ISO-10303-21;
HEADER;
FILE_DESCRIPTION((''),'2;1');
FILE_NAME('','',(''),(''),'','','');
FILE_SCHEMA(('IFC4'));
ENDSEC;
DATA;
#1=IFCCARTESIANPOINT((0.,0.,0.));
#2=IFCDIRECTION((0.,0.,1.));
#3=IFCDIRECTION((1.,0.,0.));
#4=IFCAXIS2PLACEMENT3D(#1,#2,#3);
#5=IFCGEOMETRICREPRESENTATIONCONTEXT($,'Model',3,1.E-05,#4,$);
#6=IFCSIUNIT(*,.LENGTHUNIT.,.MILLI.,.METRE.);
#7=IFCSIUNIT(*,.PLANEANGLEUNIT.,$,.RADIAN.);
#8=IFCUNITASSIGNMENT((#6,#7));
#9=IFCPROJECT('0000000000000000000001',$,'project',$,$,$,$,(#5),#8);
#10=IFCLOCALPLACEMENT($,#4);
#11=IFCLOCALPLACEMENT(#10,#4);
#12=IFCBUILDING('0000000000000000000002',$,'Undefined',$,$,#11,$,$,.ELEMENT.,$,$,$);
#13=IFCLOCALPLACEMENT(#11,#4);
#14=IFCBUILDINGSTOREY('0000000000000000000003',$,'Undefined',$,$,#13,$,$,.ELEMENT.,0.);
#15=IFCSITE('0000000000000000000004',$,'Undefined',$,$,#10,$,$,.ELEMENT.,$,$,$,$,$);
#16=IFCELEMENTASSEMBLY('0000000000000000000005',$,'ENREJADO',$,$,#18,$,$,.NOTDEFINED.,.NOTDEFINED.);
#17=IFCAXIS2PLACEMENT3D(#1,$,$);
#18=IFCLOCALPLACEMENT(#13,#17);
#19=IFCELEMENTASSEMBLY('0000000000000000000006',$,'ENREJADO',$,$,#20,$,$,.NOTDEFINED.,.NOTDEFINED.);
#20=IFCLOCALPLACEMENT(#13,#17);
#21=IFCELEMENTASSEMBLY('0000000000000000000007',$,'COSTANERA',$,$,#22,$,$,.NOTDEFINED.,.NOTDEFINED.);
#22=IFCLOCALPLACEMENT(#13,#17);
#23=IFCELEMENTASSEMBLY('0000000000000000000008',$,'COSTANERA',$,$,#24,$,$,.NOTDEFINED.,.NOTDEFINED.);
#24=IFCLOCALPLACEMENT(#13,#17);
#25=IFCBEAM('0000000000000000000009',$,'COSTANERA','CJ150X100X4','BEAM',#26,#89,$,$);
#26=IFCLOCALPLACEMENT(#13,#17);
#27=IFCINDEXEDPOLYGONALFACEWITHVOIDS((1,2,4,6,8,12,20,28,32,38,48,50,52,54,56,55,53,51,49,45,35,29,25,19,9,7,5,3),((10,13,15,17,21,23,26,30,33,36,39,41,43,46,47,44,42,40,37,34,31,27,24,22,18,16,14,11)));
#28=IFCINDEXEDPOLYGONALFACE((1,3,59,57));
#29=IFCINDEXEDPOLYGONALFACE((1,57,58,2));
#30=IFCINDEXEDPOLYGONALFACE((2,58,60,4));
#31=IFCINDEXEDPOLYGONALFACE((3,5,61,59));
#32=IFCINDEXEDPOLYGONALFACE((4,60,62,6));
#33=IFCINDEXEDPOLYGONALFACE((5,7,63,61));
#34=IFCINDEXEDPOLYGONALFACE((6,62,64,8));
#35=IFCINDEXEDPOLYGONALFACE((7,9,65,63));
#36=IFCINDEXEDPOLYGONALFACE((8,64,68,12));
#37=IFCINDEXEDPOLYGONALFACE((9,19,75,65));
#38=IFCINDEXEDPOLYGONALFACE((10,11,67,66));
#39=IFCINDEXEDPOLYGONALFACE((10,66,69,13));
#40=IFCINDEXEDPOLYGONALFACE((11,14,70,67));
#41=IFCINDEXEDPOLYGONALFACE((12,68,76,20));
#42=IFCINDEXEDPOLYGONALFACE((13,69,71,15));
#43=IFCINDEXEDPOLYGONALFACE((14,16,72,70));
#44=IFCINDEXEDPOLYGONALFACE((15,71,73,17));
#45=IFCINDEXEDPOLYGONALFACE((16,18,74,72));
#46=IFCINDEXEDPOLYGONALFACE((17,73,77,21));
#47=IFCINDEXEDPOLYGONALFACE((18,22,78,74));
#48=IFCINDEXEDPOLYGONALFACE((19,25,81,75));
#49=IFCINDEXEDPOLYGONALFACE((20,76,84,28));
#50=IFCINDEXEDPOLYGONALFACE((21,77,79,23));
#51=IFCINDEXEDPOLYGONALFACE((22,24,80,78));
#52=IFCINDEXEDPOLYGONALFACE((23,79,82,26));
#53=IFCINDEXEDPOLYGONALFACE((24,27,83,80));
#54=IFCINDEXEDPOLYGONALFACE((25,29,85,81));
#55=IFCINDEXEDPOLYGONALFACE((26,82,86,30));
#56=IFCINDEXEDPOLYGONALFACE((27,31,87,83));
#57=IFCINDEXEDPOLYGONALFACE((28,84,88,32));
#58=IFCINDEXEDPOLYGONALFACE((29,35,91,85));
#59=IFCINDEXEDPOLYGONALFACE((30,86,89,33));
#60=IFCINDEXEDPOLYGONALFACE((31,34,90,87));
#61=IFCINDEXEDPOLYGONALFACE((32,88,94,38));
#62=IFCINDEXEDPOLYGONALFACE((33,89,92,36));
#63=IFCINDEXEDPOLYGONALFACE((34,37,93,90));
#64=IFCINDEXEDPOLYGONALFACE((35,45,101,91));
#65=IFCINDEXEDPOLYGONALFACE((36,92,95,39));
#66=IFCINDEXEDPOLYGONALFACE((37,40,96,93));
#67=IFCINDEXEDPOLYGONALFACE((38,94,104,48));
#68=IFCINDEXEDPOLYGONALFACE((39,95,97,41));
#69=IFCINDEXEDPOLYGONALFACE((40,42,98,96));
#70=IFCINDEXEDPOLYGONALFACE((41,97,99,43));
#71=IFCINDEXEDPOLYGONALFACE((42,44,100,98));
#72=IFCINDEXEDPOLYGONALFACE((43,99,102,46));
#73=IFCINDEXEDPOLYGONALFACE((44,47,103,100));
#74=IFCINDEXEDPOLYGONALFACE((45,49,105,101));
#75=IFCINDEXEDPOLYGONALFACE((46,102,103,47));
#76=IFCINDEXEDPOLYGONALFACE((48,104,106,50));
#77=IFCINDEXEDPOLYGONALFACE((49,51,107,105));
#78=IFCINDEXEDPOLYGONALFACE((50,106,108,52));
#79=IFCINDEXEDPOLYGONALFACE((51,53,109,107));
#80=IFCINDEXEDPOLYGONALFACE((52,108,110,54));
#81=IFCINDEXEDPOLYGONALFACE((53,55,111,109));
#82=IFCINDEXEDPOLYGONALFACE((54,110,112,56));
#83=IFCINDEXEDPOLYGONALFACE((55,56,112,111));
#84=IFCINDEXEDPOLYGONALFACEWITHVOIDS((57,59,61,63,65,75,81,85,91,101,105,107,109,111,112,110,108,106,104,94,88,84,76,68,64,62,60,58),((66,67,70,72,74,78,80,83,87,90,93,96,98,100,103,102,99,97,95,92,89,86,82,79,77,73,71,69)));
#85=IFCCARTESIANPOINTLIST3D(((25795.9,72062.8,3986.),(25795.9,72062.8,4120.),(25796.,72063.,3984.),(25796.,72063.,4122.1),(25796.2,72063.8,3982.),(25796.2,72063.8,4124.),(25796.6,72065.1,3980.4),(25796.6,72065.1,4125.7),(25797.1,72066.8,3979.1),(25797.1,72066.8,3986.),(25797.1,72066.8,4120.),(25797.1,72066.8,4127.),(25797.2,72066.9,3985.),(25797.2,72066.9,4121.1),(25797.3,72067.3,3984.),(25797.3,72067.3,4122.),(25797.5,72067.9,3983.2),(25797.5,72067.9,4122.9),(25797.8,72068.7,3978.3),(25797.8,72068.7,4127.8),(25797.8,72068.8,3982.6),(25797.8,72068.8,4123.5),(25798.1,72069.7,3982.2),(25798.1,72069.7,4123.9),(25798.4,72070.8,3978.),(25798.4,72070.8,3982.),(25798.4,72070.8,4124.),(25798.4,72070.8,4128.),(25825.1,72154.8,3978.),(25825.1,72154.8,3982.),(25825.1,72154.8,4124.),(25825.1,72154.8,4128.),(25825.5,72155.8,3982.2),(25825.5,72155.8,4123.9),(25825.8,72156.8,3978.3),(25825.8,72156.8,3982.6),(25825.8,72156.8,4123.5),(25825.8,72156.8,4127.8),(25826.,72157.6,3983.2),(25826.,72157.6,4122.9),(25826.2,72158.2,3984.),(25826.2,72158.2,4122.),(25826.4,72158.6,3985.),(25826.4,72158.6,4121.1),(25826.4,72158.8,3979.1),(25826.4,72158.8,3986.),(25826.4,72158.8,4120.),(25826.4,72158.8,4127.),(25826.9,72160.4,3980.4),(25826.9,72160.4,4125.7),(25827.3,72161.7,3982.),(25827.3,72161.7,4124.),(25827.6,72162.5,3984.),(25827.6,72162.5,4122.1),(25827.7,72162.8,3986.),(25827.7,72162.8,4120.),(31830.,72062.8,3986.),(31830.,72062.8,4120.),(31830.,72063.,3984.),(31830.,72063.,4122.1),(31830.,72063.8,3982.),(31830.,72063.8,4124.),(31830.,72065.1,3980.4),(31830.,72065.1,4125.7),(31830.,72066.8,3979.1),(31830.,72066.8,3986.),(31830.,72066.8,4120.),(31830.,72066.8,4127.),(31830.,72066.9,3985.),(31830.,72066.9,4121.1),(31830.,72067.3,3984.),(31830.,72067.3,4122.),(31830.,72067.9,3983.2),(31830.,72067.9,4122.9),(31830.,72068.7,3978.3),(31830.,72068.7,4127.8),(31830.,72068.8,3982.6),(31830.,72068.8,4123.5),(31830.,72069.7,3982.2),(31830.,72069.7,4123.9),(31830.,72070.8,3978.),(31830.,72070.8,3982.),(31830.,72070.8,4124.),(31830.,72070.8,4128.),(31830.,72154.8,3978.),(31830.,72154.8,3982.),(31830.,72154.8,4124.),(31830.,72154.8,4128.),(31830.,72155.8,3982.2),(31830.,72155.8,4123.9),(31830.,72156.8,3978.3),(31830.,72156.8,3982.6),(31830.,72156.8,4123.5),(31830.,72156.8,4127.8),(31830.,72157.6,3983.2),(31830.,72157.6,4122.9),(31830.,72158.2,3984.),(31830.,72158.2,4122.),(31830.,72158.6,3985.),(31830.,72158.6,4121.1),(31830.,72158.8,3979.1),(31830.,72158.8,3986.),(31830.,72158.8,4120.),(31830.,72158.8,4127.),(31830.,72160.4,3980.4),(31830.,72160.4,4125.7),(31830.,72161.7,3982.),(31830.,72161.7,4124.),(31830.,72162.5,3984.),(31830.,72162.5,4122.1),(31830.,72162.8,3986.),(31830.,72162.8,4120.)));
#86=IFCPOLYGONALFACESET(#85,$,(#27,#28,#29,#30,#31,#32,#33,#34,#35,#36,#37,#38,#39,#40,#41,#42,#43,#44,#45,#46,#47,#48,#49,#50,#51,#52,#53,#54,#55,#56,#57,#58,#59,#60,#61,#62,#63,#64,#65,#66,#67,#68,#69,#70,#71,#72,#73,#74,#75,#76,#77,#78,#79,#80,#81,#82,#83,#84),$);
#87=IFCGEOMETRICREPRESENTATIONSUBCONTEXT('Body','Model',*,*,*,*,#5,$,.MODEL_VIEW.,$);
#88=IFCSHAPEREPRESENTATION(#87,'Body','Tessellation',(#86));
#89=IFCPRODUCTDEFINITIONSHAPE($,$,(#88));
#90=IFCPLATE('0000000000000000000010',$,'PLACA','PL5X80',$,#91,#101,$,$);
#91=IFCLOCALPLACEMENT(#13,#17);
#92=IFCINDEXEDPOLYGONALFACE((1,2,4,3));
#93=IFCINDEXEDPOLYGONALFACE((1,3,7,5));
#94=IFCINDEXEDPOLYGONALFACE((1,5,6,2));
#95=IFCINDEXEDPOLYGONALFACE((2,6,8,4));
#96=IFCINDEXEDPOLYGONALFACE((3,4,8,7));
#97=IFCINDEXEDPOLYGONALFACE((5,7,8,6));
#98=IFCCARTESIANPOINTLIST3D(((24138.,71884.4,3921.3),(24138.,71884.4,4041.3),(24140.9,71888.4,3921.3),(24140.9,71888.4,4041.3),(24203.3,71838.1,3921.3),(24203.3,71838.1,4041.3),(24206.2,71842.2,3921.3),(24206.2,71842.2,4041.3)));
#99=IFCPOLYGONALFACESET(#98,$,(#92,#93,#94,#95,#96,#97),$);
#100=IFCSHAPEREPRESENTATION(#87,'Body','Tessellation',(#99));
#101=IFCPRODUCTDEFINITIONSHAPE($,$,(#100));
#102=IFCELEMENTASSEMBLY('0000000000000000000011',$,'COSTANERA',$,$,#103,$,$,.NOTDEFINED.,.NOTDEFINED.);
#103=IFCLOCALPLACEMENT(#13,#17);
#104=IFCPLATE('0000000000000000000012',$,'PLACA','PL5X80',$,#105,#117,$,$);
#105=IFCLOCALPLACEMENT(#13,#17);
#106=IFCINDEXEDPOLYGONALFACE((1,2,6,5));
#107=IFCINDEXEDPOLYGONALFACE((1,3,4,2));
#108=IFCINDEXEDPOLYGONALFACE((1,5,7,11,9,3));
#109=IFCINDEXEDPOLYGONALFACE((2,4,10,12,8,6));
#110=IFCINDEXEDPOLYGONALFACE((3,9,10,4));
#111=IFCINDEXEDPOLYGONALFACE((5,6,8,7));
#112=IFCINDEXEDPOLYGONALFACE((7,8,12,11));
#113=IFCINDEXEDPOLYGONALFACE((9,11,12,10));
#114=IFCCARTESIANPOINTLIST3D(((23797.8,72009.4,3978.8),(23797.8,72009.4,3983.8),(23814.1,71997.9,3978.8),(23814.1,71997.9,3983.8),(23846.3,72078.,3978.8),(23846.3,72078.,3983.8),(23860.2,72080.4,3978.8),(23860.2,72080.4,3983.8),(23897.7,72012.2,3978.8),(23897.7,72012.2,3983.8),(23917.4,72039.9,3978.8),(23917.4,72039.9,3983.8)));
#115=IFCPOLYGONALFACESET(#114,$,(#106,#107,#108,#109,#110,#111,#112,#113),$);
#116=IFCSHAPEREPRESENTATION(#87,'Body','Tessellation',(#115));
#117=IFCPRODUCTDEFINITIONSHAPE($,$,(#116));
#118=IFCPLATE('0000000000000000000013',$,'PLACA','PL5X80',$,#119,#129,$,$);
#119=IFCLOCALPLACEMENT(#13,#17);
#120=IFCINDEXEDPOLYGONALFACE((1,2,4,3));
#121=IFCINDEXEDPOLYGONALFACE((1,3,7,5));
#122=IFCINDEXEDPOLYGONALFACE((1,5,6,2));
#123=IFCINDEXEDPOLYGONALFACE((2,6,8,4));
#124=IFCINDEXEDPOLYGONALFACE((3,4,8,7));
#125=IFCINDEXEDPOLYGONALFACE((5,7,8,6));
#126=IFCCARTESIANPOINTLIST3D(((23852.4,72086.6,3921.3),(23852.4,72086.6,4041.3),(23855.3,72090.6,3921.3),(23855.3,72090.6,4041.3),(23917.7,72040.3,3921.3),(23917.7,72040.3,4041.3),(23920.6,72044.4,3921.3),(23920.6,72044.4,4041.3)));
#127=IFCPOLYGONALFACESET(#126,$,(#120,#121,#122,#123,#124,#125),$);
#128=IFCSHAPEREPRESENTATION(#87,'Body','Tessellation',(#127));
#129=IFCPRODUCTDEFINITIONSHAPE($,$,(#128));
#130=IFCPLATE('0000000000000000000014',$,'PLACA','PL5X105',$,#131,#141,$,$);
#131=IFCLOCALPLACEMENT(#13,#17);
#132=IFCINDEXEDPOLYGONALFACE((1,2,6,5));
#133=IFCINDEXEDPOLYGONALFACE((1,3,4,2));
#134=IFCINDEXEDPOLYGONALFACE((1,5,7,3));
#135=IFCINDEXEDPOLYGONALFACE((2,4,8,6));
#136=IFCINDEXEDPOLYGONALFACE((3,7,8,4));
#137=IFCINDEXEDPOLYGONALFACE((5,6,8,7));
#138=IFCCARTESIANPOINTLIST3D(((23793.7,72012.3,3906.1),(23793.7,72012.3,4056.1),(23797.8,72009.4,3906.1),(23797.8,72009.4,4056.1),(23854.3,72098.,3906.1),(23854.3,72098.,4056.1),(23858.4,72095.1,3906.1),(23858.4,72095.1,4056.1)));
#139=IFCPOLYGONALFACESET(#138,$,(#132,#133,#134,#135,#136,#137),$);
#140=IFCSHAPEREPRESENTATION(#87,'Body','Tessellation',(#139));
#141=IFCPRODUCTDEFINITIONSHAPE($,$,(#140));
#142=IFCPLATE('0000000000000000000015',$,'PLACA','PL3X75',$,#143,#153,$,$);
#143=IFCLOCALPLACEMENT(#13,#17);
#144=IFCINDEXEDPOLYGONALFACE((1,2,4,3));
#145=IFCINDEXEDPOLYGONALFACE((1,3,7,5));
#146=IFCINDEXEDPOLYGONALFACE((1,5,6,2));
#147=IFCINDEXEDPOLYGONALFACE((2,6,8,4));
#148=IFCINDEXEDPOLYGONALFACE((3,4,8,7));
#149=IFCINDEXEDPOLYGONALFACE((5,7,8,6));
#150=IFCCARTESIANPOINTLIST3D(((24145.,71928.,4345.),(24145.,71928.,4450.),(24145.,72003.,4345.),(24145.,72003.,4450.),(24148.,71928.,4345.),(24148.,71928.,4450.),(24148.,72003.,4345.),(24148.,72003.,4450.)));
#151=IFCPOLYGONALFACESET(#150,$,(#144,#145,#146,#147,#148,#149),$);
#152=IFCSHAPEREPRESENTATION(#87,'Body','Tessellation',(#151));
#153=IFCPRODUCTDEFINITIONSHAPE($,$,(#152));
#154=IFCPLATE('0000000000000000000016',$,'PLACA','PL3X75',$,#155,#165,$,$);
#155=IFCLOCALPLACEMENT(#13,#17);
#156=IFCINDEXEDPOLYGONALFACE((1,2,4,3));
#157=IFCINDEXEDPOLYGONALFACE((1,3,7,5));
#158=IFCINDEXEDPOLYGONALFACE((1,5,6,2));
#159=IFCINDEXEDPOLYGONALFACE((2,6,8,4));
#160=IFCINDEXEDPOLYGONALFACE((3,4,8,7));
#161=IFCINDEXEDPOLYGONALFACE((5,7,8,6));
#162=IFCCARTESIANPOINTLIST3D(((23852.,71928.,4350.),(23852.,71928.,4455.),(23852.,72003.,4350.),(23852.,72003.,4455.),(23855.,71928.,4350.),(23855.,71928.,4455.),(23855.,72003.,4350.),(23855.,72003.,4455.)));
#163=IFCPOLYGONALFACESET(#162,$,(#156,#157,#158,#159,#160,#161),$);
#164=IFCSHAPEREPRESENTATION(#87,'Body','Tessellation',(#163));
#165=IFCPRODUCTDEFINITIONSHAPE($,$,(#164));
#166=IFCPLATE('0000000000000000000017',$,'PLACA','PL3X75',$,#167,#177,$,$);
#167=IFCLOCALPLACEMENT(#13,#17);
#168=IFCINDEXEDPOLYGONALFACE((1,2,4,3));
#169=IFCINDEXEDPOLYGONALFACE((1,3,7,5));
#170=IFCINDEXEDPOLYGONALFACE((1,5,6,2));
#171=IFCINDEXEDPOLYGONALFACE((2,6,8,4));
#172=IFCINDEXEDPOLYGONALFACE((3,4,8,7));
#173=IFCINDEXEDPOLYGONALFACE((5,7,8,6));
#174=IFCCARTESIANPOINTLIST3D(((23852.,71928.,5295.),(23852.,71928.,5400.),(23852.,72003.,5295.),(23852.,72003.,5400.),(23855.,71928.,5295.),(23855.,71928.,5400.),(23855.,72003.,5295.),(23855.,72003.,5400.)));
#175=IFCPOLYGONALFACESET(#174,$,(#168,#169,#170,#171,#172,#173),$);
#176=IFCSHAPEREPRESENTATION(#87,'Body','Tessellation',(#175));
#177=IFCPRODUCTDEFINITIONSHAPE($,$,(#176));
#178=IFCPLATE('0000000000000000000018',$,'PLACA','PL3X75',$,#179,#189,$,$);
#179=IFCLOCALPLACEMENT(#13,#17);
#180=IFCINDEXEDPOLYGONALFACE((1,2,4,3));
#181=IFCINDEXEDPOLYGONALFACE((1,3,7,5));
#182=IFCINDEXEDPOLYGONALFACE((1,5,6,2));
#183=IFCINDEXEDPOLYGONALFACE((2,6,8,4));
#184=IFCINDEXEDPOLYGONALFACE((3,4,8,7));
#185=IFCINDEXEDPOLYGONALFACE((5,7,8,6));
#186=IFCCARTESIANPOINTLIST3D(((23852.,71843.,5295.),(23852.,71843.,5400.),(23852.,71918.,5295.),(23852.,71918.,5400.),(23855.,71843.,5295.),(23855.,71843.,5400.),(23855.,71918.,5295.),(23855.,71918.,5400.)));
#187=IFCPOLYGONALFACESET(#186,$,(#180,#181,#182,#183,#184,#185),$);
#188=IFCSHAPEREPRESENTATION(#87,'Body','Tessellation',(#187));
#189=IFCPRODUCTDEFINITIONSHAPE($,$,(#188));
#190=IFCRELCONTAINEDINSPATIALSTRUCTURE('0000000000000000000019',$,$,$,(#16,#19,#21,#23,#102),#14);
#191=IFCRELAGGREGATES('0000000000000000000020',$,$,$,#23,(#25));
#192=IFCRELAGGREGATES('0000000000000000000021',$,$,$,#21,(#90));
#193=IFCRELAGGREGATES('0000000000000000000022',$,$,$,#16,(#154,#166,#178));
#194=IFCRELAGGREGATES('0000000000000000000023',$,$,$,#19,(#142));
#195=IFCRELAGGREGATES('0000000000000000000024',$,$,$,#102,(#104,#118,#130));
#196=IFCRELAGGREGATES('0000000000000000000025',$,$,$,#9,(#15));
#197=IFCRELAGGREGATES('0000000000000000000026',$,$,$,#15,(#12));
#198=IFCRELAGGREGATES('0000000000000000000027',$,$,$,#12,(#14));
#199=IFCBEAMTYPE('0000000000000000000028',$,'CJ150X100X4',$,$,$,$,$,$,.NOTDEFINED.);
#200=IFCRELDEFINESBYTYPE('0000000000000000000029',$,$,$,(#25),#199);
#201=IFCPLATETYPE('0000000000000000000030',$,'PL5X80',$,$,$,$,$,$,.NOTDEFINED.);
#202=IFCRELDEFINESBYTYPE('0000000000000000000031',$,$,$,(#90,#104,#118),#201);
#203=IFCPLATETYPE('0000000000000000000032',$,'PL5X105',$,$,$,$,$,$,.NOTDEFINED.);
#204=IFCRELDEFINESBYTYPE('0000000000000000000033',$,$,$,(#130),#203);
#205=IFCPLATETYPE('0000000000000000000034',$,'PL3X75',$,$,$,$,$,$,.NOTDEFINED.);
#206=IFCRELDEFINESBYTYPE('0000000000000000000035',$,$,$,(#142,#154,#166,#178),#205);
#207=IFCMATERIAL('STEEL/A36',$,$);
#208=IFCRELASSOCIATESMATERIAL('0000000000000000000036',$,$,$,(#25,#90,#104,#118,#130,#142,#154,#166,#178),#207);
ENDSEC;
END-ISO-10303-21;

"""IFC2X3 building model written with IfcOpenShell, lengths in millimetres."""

from ifc_helpers import new_model, si_unit, frame, origin_with_axes, origin_2d_with_axis, place, context, subcontext, project, spatial, polyline, hollow_rectangle, outline, extrude, clip, halfspace, material, type_object, element, aggregate, save


model = new_model("IFC2X3")

# Units and contexts
model_context = context("Model", 3, precision=1e-05, world=origin_with_axes())
body_context = subcontext(model_context, "Body", "Model", "MODEL_VIEW")
ifc_project = project(units=[si_unit("LENGTHUNIT", "METRE", prefix="MILLI"), si_unit("PLANEANGLEUNIT", "RADIAN")], contexts=[model_context])

# Site, building, storey
site_placement = place(None, origin_with_axes())
site = spatial("IfcSite", under=ifc_project, at=site_placement, Name="Undefined", CompositionType="ELEMENT")
building_placement = place(site_placement, origin_with_axes())
building = spatial("IfcBuilding", under=site, at=building_placement, Name="Undefined", CompositionType="ELEMENT")
storey_placement = place(building_placement, origin_with_axes())
storey = spatial("IfcBuildingStorey", under=building, at=storey_placement, Name="Undefined", CompositionType="ELEMENT", Elevation=0.0)

# Element assemblies
assembly_1_placement = place(storey_placement, origin_with_axes())
assembly_1 = element("IfcElementAssembly", 1, at=assembly_1_placement, inside=storey, Name="ENREJADO", AssemblyPlace="NOTDEFINED", PredefinedType="NOTDEFINED")
ifc_material_1 = material(Name="STEEL/A36")
assembly_2_placement = place(storey_placement, origin_with_axes())
assembly_2 = element("IfcElementAssembly", 2, at=assembly_2_placement, inside=storey, Name="ENREJADO", AssemblyPlace="NOTDEFINED", PredefinedType="NOTDEFINED")

# Element assemblies, beam
assembly_3_placement = place(storey_placement, origin_with_axes())
assembly_3 = element("IfcElementAssembly", 3, at=assembly_3_placement, inside=storey, Name="COSTANERA", AssemblyPlace="NOTDEFINED", PredefinedType="NOTDEFINED")
beam_type_1 = type_object("IfcBeamType", Name="CJ150X100X4", PredefinedType="NOTDEFINED")
assembly_4_placement = place(storey_placement, origin_with_axes())
assembly_4 = element("IfcElementAssembly", 4, at=assembly_4_placement, inside=storey, Name="COSTANERA", AssemblyPlace="NOTDEFINED", PredefinedType="NOTDEFINED")
beam_1_placement = place(assembly_4_placement, frame((25811.8, 72112.8, 4053.0), z_axis=(0.0, 0.0, 1.0), x_axis=(1.0, 0.0, 0.0)))
beam_1 = element("IfcBeam", 5, at=beam_1_placement, type_object=beam_type_1, material=ifc_material_1, Name="COSTANERA", Description="CJ150X100X4", ObjectType="BEAM", context=body_context, shape_type="Clipping", body=[
    clip(clip(extrude(hollow_rectangle(XDim=100.0, YDim=150.0, WallThickness=4.0, InnerFilletRadius=4.0, OuterFilletRadius=8.0, at=origin_2d_with_axis()), frame((6188.2, 0.0, 0.0), z_axis=(-1.0, 0.0, 0.0), x_axis=(0.0, -1.0, 0.0)), (0.0, 0.0, 1.0), 6204.3), halfspace(frame((6018.2, 44.8, -480.0), z_axis=(-1.0, 0.0, 0.0), x_axis=(0.0, 0.0, 1.0)), True)), halfspace(frame((15.9, 50.0, 0.0), z_axis=(-0.952956, 0.30311, 0.0), x_axis=(0.0, 0.0, 1.0)), False)),
])
aggregate(assembly_4, [beam_1])

# Plate
plate_type_1 = type_object("IfcPlateType", Name="PL5X80", PredefinedType="NOTDEFINED")
plate_1_placement = place(assembly_3_placement, frame((24139.5, 71886.4, 4041.3), z_axis=(0.577701, 0.816249, 0.0), x_axis=(0.816249, -0.577701, 0.0)))
plate_1 = element("IfcPlate", 6, at=plate_1_placement, type_object=plate_type_1, material=ifc_material_1, Name="PLACA", Description="PL5X80", context=body_context, shape_type="SweptSolid", body=[
    extrude(outline(polyline([(0.0, 0.0), (80.0, 0.0), (80.0, 120.0), (0.0, 120.0), (0.0, 0.0)])), frame((0.0, 0.0, -2.5), z_axis=(0.0, 0.0, 1.0), x_axis=(1.0, 0.0, 0.0)), (0.0, 0.0, 1.0), 5.0),
])
aggregate(assembly_3, [plate_1])

# Element assembly, plates
assembly_5_placement = place(storey_placement, origin_with_axes())
assembly_5 = element("IfcElementAssembly", 7, at=assembly_5_placement, inside=storey, Name="COSTANERA", AssemblyPlace="NOTDEFINED", PredefinedType="NOTDEFINED")
plate_2_placement = place(assembly_5_placement, frame((23917.4, 72039.9, 3981.3), z_axis=(0.0, 0.0, 1.0), x_axis=(-0.816249, 0.577701, 0.0)))
plate_2 = element("IfcPlate", 8, at=plate_2_placement, type_object=plate_type_1, material=ifc_material_1, Name="PLACA", Description="PL5X80", context=body_context, shape_type="SweptSolid", body=[
    extrude(outline(polyline([(0.0, 0.0), (70.0, 0.0), (80.0, 10.0), (80.0, 94.0), (60.0, 94.0), (0.0, 34.0), (0.0, 0.0)])), frame((0.0, 0.0, -2.5), z_axis=(0.0, 0.0, 1.0), x_axis=(1.0, 0.0, 0.0)), (0.0, 0.0, 1.0), 5.0),
])
plate_3_placement = place(assembly_5_placement, frame((23919.1, 72042.4, 4041.3), z_axis=(-0.577701, -0.816249, 0.0), x_axis=(-0.816249, 0.577701, 0.0)))
plate_3 = element("IfcPlate", 9, at=plate_3_placement, type_object=plate_type_1, material=ifc_material_1, Name="PLACA", Description="PL5X80", context=body_context, shape_type="SweptSolid", body=[
    extrude(outline(polyline([(0.0, 0.0), (80.0, 0.0), (80.0, 120.0), (0.0, 120.0), (0.0, 0.0)])), frame((0.0, 0.0, -2.5), z_axis=(0.0, 0.0, 1.0), x_axis=(1.0, 0.0, 0.0)), (0.0, 0.0, 1.0), 5.0),
])
plate_type_2 = type_object("IfcPlateType", Name="PL5X105", PredefinedType="NOTDEFINED")
plate_4_placement = place(assembly_5_placement, frame((23856.4, 72096.6, 3906.1), z_axis=(-0.816249, 0.577701, 0.0), x_axis=(-0.577701, -0.816249, 0.0)))
plate_4 = element("IfcPlate", 10, at=plate_4_placement, type_object=plate_type_2, material=ifc_material_1, Name="PLACA", Description="PL5X105", context=body_context, shape_type="SweptSolid", body=[
    extrude(outline(polyline([(0.0, 0.0), (105.0, 0.0), (105.0, 150.0), (0.0, 150.0), (0.0, 0.0)])), frame((0.0, 0.0, -2.5), z_axis=(0.0, 0.0, 1.0), x_axis=(1.0, 0.0, 0.0)), (0.0, 0.0, 1.0), 5.0),
])

# Plates
plate_type_3 = type_object("IfcPlateType", Name="PL3X75", PredefinedType="NOTDEFINED")
plate_5_placement = place(assembly_2_placement, frame((24146.5, 71928.0, 4345.0), z_axis=(1.0, 0.0, 0.0), x_axis=(0.0, 1.0, 0.0)))
plate_5 = element("IfcPlate", 11, at=plate_5_placement, type_object=plate_type_3, material=ifc_material_1, Name="PLACA", Description="PL3X75", context=body_context, shape_type="SweptSolid", body=[
    extrude(outline(polyline([(0.0, 0.0), (75.0, 0.0), (75.0, 105.0), (0.0, 105.0), (0.0, 0.0)])), frame((0.0, 0.0, -1.5), z_axis=(0.0, 0.0, 1.0), x_axis=(1.0, 0.0, 0.0)), (0.0, 0.0, 1.0), 3.0),
])
plate_6_placement = place(assembly_1_placement, frame((23853.5, 71928.0, 4455.0), z_axis=(-1.0, 0.0, 0.0), x_axis=(0.0, 1.0, 0.0)))
plate_6 = element("IfcPlate", 12, at=plate_6_placement, type_object=plate_type_3, material=ifc_material_1, Name="PLACA", Description="PL3X75", context=body_context, shape_type="SweptSolid", body=[
    extrude(outline(polyline([(0.0, 0.0), (75.0, 0.0), (75.0, 105.0), (0.0, 105.0), (0.0, 0.0)])), frame((0.0, 0.0, -1.5), z_axis=(0.0, 0.0, 1.0), x_axis=(1.0, 0.0, 0.0)), (0.0, 0.0, 1.0), 3.0),
])
plate_7_placement = place(assembly_1_placement, frame((23853.5, 72003.0, 5295.0), z_axis=(-1.0, 0.0, 0.0), x_axis=(0.0, -1.0, 0.0)))
plate_7 = element("IfcPlate", 13, at=plate_7_placement, type_object=plate_type_3, material=ifc_material_1, Name="PLACA", Description="PL3X75", context=body_context, shape_type="SweptSolid", body=[
    extrude(outline(polyline([(0.0, 0.0), (75.0, 0.0), (75.0, 105.0), (0.0, 105.0), (0.0, 0.0)])), frame((0.0, 0.0, -1.5), z_axis=(0.0, 0.0, 1.0), x_axis=(1.0, 0.0, 0.0)), (0.0, 0.0, 1.0), 3.0),
])
plate_8_placement = place(assembly_1_placement, frame((23853.5, 71918.0, 5295.0), z_axis=(-1.0, 0.0, 0.0), x_axis=(0.0, -1.0, 0.0)))
plate_8 = element("IfcPlate", 14, at=plate_8_placement, type_object=plate_type_3, material=ifc_material_1, Name="PLACA", Description="PL3X75", context=body_context, shape_type="SweptSolid", body=[
    extrude(outline(polyline([(0.0, 0.0), (75.0, 0.0), (75.0, 105.0), (0.0, 105.0), (0.0, 0.0)])), frame((0.0, 0.0, -1.5), z_axis=(0.0, 0.0, 1.0), x_axis=(1.0, 0.0, 0.0)), (0.0, 0.0, 1.0), 3.0),
])
aggregate(assembly_1, [plate_6, plate_7, plate_8])
aggregate(assembly_2, [plate_5])

aggregate(assembly_5, [plate_2, plate_3, plate_4])

save(model, "model.ifc")
